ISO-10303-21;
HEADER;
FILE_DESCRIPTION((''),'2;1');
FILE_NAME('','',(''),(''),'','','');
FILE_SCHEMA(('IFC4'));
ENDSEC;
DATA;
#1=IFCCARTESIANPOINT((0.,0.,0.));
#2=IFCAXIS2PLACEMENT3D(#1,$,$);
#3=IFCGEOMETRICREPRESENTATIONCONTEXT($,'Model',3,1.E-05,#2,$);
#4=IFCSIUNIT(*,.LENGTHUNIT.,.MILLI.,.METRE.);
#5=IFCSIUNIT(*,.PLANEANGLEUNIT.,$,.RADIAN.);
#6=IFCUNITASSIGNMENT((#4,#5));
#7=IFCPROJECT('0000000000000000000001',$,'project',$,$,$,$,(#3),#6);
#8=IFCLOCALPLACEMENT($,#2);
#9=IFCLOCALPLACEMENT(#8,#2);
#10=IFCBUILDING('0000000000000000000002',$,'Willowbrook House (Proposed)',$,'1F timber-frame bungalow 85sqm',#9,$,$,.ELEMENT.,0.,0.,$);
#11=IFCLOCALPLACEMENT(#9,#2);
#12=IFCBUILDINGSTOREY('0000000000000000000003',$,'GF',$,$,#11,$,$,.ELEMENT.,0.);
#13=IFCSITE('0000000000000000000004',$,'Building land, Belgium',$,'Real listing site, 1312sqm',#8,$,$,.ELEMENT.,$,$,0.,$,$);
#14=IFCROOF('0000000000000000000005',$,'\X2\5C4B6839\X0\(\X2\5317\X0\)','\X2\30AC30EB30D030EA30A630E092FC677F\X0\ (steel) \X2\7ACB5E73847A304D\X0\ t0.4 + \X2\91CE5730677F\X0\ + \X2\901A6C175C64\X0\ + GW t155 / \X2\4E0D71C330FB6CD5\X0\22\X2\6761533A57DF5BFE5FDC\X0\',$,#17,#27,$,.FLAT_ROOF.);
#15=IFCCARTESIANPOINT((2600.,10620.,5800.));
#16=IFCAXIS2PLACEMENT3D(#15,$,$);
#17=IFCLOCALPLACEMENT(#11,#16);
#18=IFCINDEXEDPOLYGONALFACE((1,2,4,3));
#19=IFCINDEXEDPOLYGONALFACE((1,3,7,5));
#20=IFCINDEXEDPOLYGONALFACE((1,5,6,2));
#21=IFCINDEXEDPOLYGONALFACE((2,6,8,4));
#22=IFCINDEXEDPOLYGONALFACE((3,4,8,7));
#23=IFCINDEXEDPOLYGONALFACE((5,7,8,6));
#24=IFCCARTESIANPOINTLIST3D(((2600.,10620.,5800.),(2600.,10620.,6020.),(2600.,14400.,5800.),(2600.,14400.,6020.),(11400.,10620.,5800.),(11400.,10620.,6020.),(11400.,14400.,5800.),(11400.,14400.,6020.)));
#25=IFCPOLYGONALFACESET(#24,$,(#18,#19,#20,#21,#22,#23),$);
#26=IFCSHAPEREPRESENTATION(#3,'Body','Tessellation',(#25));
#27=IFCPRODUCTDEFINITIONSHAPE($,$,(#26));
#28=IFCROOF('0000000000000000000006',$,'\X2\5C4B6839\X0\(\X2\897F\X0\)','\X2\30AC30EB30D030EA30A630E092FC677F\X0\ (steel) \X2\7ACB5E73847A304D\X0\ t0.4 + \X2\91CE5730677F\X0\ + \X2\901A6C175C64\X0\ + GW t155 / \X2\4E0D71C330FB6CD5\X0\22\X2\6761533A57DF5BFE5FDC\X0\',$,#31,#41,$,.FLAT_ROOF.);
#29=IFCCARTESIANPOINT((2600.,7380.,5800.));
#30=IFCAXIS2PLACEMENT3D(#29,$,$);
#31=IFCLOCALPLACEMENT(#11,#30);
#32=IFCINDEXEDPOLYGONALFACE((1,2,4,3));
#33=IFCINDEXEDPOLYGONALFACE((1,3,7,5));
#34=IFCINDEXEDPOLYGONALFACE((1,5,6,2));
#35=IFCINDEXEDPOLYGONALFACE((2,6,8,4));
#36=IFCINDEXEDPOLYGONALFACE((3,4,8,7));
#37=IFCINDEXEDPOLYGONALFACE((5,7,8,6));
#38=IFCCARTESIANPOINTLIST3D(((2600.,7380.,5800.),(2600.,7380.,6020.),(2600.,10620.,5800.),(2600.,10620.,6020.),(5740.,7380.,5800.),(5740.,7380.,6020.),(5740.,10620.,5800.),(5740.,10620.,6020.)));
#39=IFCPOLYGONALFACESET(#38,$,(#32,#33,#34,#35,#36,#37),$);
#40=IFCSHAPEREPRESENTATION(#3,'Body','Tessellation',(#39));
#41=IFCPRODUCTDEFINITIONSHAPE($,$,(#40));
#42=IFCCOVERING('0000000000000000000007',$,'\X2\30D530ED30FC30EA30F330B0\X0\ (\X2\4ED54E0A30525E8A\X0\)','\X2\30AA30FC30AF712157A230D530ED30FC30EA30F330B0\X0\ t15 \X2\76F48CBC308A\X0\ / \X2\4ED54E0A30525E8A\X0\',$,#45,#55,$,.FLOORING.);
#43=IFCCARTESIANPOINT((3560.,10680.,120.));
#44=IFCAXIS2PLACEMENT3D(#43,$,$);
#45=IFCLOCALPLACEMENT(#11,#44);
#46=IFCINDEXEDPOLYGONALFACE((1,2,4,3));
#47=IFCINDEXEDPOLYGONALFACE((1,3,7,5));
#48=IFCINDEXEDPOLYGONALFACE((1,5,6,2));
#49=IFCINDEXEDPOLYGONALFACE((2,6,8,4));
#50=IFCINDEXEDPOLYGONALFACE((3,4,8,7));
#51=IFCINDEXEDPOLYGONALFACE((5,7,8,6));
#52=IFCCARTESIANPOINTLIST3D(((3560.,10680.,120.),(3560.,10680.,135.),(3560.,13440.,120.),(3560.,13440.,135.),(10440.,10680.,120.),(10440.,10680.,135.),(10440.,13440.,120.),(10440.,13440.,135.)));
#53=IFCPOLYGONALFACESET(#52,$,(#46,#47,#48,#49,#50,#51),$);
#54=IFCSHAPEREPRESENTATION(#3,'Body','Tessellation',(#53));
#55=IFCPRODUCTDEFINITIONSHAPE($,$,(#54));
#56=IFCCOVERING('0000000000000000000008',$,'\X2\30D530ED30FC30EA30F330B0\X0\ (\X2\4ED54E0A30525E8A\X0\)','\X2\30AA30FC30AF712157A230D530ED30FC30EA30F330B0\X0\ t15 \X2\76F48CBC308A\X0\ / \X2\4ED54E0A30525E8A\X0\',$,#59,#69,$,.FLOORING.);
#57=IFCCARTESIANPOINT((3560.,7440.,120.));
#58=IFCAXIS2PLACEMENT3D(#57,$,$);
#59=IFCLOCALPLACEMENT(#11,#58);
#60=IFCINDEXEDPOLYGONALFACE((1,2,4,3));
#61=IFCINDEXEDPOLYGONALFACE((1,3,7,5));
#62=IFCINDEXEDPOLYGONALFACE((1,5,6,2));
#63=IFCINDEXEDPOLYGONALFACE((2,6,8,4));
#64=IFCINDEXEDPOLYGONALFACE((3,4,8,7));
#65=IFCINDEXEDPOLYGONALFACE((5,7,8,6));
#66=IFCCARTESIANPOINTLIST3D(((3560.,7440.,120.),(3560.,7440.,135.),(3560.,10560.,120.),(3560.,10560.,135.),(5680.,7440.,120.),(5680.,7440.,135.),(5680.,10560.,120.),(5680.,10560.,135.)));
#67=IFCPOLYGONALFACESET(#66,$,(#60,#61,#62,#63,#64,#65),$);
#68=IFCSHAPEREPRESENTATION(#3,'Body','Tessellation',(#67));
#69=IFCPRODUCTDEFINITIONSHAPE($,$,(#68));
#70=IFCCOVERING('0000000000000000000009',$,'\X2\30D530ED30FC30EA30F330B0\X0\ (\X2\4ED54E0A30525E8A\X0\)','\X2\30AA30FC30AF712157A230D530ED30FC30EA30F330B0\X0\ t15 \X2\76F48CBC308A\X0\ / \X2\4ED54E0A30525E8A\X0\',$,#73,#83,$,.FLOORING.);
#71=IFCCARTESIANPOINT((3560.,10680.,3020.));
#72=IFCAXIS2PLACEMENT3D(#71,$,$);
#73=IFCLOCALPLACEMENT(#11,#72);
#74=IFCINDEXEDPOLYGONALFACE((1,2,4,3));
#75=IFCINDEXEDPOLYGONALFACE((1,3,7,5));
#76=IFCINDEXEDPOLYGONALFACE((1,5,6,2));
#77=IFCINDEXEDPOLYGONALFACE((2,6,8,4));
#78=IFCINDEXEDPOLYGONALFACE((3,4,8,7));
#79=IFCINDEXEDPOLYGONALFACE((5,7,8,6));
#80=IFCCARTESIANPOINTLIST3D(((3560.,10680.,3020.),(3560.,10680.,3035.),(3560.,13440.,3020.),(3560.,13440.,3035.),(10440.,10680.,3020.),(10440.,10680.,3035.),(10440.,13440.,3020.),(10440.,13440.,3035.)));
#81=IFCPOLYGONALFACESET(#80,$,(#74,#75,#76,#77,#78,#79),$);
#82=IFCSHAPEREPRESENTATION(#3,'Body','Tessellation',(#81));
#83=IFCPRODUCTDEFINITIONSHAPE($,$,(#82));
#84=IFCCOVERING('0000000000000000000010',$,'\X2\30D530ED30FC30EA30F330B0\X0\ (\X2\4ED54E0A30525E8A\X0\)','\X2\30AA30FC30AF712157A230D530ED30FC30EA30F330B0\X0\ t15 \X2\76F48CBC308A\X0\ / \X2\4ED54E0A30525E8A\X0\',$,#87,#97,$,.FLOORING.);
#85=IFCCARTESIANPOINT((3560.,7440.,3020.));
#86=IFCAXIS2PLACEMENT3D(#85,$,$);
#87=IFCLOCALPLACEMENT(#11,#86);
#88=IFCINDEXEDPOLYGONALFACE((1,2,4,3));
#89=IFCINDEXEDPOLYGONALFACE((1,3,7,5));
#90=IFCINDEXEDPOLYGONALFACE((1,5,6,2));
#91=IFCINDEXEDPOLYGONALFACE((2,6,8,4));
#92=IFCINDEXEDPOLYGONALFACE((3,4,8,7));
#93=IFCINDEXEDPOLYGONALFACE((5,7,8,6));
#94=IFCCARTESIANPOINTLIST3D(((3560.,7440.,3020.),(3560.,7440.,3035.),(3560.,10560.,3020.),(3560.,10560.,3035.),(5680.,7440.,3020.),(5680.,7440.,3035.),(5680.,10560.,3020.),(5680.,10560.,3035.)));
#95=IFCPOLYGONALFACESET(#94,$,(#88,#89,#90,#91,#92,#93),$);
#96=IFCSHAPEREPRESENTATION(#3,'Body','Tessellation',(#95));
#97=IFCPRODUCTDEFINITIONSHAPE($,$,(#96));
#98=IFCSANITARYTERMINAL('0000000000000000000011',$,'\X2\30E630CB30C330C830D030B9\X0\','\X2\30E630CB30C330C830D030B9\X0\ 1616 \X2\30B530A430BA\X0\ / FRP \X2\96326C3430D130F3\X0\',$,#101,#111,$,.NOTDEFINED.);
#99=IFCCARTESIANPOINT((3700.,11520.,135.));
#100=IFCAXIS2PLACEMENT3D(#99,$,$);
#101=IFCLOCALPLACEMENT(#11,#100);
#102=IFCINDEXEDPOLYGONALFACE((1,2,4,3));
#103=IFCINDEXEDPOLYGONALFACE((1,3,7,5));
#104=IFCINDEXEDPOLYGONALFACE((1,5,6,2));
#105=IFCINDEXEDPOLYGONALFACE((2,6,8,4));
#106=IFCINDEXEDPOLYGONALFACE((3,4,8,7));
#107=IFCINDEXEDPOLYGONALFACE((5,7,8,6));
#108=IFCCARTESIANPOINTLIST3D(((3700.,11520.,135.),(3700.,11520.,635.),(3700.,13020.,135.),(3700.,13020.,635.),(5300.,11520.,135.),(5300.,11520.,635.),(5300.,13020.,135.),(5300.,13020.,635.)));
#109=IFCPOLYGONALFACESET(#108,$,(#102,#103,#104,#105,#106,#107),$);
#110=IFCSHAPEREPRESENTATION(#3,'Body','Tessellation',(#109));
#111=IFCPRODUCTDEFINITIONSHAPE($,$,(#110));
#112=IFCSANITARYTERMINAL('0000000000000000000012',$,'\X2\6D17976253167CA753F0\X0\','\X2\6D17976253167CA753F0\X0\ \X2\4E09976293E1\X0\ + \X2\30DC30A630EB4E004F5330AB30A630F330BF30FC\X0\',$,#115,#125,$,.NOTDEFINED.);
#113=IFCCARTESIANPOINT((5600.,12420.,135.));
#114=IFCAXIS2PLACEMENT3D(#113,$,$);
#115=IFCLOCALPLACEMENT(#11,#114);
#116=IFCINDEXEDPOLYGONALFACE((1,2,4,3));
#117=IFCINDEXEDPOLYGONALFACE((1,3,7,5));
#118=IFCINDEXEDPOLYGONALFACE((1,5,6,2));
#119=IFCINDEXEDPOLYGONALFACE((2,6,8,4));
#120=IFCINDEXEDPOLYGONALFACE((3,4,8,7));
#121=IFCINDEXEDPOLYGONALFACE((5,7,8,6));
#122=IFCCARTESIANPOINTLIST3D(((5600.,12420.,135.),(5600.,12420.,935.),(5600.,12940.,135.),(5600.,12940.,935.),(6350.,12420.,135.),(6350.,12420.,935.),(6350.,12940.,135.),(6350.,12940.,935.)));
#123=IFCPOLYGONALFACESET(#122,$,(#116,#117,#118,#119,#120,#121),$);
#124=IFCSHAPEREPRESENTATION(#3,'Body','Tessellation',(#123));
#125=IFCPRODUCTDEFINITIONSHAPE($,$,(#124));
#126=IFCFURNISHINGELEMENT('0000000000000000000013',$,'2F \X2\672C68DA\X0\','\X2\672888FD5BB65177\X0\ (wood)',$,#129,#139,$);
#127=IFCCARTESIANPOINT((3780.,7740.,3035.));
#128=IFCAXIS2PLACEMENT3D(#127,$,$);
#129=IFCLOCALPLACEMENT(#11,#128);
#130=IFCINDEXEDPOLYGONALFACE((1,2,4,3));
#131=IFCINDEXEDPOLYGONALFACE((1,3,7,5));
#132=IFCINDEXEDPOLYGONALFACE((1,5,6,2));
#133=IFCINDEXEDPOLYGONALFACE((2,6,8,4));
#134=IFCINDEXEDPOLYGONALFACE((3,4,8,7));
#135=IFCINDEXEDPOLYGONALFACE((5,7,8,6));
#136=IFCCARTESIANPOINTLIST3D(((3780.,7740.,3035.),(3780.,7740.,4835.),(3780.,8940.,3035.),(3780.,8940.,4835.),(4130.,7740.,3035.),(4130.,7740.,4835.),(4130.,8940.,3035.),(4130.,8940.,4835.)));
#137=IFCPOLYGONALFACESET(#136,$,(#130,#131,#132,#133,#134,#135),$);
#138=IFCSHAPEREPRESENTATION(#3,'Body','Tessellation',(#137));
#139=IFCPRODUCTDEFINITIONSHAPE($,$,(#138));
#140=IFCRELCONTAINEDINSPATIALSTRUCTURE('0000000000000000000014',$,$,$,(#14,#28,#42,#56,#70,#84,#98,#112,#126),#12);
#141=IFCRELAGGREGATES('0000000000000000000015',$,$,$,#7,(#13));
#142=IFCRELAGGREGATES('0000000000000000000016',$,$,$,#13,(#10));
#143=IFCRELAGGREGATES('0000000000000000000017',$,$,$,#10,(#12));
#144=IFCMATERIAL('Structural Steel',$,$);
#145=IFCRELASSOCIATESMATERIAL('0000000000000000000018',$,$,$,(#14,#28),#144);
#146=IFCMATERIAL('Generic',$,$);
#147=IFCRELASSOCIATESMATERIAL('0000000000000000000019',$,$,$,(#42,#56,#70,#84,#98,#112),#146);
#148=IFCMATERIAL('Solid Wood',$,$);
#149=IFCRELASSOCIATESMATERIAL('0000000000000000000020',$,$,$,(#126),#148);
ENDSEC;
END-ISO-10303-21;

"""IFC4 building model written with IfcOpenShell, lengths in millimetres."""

from ifc_helpers import new_model, si_unit, frame, frame_2d, origin, place, context, project, spatial, rectangle, extrude, material, element, save


model = new_model("IFC4")

# Units and contexts
model_context = context("Model", 3, precision=1e-05, world=origin())
ifc_project = project(units=[si_unit("LENGTHUNIT", "METRE", prefix="MILLI"), si_unit("PLANEANGLEUNIT", "RADIAN")], contexts=[model_context])

# Site, building, storey
site_placement = place(None, origin())
site = spatial("IfcSite", under=ifc_project, at=site_placement, Name="Building land, Belgium", ObjectType="Real listing site, 1312sqm", CompositionType="ELEMENT", RefElevation=0.0)
building_placement = place(site_placement, origin())
building = spatial("IfcBuilding", under=site, at=building_placement, Name="Willowbrook House (Proposed)", ObjectType="1F timber-frame bungalow 85sqm", CompositionType="ELEMENT", ElevationOfRefHeight=0.0, ElevationOfTerrain=0.0)
storey_placement = place(building_placement, origin())
storey = spatial("IfcBuildingStorey", under=building, at=storey_placement, Name="GF", CompositionType="ELEMENT", Elevation=0.0)

# Shared definitions
ifc_material_1 = material(Name="Solid Wood")

# Roofs
ifc_material_2 = material(Name="Structural Steel")
for number, where, name in (
    (1, (2600.0, 10620.0, 5800.0), "屋根(北)"),
):
    element("IfcRoof", number, at=place(storey_placement, frame(where)), inside=storey, material=ifc_material_2, Name=name, Description="ガルバリウム鋼板 (steel) 立平葺き t0.4 + 野地板 + 通気層 + GW t155 / 不燃・法22条区域対応", PredefinedType="FLAT_ROOF", context=model_context, shape_type="SweptSolid", body=[
        extrude(rectangle(XDim=8800.0, YDim=3780.0, at=frame_2d((4400.0, 1890.0))), frame((2600.0, 10620.0, 5800.0)), (0.0, 0.0, 1.0), 220.0),
    ])
roof_placement = place(storey_placement, frame((2600.0, 7380.0, 5800.0)))
element("IfcRoof", 2, at=roof_placement, inside=storey, material=ifc_material_2, Name="屋根(西)", Description="ガルバリウム鋼板 (steel) 立平葺き t0.4 + 野地板 + 通気層 + GW t155 / 不燃・法22条区域対応", PredefinedType="FLAT_ROOF", context=model_context, shape_type="SweptSolid", body=[
    extrude(rectangle(XDim=3140.0, YDim=3240.0, at=frame_2d((1570.0, 1620.0))), frame((2600.0, 7380.0, 5800.0)), (0.0, 0.0, 1.0), 220.0),
])

# Coverings
ifc_material_3 = material(Name="Generic")
covering_1_placement = place(storey_placement, frame((3560.0, 10680.0, 120.0)))
element("IfcCovering", 3, at=covering_1_placement, inside=storey, material=ifc_material_3, Name="フローリング (仕上げ床)", Description="オーク無垢フローリング t15 直貼り / 仕上げ床", PredefinedType="FLOORING", context=model_context, shape_type="SweptSolid", body=[
    extrude(rectangle(XDim=6880.0, YDim=2760.0, at=frame_2d((3440.0, 1380.0))), frame((3560.0, 10680.0, 120.0)), (0.0, 0.0, 1.0), 15.0),
])
covering_2_placement = place(storey_placement, frame((3560.0, 7440.0, 120.0)))
element("IfcCovering", 4, at=covering_2_placement, inside=storey, material=ifc_material_3, Name="フローリング (仕上げ床)", Description="オーク無垢フローリング t15 直貼り / 仕上げ床", PredefinedType="FLOORING", context=model_context, shape_type="SweptSolid", body=[
    extrude(rectangle(XDim=2120.0, YDim=3120.0, at=frame_2d((1060.0, 1560.0))), frame((3560.0, 7440.0, 120.0)), (0.0, 0.0, 1.0), 15.0),
])
covering_3_placement = place(storey_placement, frame((3560.0, 10680.0, 3020.0)))
element("IfcCovering", 5, at=covering_3_placement, inside=storey, material=ifc_material_3, Name="フローリング (仕上げ床)", Description="オーク無垢フローリング t15 直貼り / 仕上げ床", PredefinedType="FLOORING", context=model_context, shape_type="SweptSolid", body=[
    extrude(rectangle(XDim=6880.0, YDim=2760.0, at=frame_2d((3440.0, 1380.0))), frame((3560.0, 10680.0, 3020.0)), (0.0, 0.0, 1.0), 15.0),
])
covering_4_placement = place(storey_placement, frame((3560.0, 7440.0, 3020.0)))
element("IfcCovering", 6, at=covering_4_placement, inside=storey, material=ifc_material_3, Name="フローリング (仕上げ床)", Description="オーク無垢フローリング t15 直貼り / 仕上げ床", PredefinedType="FLOORING", context=model_context, shape_type="SweptSolid", body=[
    extrude(rectangle(XDim=2120.0, YDim=3120.0, at=frame_2d((1060.0, 1560.0))), frame((3560.0, 7440.0, 3020.0)), (0.0, 0.0, 1.0), 15.0),
])

# Sanitary terminals
sanitary_terminal_1_placement = place(storey_placement, frame((3700.0, 11520.0, 135.0)))
element("IfcSanitaryTerminal", 7, at=sanitary_terminal_1_placement, inside=storey, material=ifc_material_3, Name="ユニットバス", Description="ユニットバス 1616 サイズ / FRP 防水パン", PredefinedType="NOTDEFINED", context=model_context, shape_type="SweptSolid", body=[
    extrude(rectangle(XDim=1600.0, YDim=1500.0, at=frame_2d((800.0, 750.0))), frame((3700.0, 11520.0, 135.0)), (0.0, 0.0, 1.0), 500.0),
])
sanitary_terminal_2_placement = place(storey_placement, frame((5600.0, 12420.0, 135.0)))
element("IfcSanitaryTerminal", 8, at=sanitary_terminal_2_placement, inside=storey, material=ifc_material_3, Name="洗面化粧台", Description="洗面化粧台 三面鏡 + ボウル一体カウンター", PredefinedType="NOTDEFINED", context=model_context, shape_type="SweptSolid", body=[
    extrude(rectangle(XDim=750.0, YDim=520.0, at=frame_2d((375.0, 260.0))), frame((5600.0, 12420.0, 135.0)), (0.0, 0.0, 1.0), 800.0),
])

# Furnishing element
furnishing_placement = place(storey_placement, frame((3780.0, 7740.0, 3035.0)))
element("IfcFurnishingElement", 9, at=furnishing_placement, inside=storey, material=ifc_material_1, Name="2F 本棚", Description="木製家具 (wood)", context=model_context, shape_type="SweptSolid", body=[
    extrude(rectangle(XDim=350.0, YDim=1200.0, at=frame_2d((175.0, 600.0))), frame((3780.0, 7740.0, 3035.0)), (0.0, 0.0, 1.0), 1800.0),
])

save(model, "model.ifc")
